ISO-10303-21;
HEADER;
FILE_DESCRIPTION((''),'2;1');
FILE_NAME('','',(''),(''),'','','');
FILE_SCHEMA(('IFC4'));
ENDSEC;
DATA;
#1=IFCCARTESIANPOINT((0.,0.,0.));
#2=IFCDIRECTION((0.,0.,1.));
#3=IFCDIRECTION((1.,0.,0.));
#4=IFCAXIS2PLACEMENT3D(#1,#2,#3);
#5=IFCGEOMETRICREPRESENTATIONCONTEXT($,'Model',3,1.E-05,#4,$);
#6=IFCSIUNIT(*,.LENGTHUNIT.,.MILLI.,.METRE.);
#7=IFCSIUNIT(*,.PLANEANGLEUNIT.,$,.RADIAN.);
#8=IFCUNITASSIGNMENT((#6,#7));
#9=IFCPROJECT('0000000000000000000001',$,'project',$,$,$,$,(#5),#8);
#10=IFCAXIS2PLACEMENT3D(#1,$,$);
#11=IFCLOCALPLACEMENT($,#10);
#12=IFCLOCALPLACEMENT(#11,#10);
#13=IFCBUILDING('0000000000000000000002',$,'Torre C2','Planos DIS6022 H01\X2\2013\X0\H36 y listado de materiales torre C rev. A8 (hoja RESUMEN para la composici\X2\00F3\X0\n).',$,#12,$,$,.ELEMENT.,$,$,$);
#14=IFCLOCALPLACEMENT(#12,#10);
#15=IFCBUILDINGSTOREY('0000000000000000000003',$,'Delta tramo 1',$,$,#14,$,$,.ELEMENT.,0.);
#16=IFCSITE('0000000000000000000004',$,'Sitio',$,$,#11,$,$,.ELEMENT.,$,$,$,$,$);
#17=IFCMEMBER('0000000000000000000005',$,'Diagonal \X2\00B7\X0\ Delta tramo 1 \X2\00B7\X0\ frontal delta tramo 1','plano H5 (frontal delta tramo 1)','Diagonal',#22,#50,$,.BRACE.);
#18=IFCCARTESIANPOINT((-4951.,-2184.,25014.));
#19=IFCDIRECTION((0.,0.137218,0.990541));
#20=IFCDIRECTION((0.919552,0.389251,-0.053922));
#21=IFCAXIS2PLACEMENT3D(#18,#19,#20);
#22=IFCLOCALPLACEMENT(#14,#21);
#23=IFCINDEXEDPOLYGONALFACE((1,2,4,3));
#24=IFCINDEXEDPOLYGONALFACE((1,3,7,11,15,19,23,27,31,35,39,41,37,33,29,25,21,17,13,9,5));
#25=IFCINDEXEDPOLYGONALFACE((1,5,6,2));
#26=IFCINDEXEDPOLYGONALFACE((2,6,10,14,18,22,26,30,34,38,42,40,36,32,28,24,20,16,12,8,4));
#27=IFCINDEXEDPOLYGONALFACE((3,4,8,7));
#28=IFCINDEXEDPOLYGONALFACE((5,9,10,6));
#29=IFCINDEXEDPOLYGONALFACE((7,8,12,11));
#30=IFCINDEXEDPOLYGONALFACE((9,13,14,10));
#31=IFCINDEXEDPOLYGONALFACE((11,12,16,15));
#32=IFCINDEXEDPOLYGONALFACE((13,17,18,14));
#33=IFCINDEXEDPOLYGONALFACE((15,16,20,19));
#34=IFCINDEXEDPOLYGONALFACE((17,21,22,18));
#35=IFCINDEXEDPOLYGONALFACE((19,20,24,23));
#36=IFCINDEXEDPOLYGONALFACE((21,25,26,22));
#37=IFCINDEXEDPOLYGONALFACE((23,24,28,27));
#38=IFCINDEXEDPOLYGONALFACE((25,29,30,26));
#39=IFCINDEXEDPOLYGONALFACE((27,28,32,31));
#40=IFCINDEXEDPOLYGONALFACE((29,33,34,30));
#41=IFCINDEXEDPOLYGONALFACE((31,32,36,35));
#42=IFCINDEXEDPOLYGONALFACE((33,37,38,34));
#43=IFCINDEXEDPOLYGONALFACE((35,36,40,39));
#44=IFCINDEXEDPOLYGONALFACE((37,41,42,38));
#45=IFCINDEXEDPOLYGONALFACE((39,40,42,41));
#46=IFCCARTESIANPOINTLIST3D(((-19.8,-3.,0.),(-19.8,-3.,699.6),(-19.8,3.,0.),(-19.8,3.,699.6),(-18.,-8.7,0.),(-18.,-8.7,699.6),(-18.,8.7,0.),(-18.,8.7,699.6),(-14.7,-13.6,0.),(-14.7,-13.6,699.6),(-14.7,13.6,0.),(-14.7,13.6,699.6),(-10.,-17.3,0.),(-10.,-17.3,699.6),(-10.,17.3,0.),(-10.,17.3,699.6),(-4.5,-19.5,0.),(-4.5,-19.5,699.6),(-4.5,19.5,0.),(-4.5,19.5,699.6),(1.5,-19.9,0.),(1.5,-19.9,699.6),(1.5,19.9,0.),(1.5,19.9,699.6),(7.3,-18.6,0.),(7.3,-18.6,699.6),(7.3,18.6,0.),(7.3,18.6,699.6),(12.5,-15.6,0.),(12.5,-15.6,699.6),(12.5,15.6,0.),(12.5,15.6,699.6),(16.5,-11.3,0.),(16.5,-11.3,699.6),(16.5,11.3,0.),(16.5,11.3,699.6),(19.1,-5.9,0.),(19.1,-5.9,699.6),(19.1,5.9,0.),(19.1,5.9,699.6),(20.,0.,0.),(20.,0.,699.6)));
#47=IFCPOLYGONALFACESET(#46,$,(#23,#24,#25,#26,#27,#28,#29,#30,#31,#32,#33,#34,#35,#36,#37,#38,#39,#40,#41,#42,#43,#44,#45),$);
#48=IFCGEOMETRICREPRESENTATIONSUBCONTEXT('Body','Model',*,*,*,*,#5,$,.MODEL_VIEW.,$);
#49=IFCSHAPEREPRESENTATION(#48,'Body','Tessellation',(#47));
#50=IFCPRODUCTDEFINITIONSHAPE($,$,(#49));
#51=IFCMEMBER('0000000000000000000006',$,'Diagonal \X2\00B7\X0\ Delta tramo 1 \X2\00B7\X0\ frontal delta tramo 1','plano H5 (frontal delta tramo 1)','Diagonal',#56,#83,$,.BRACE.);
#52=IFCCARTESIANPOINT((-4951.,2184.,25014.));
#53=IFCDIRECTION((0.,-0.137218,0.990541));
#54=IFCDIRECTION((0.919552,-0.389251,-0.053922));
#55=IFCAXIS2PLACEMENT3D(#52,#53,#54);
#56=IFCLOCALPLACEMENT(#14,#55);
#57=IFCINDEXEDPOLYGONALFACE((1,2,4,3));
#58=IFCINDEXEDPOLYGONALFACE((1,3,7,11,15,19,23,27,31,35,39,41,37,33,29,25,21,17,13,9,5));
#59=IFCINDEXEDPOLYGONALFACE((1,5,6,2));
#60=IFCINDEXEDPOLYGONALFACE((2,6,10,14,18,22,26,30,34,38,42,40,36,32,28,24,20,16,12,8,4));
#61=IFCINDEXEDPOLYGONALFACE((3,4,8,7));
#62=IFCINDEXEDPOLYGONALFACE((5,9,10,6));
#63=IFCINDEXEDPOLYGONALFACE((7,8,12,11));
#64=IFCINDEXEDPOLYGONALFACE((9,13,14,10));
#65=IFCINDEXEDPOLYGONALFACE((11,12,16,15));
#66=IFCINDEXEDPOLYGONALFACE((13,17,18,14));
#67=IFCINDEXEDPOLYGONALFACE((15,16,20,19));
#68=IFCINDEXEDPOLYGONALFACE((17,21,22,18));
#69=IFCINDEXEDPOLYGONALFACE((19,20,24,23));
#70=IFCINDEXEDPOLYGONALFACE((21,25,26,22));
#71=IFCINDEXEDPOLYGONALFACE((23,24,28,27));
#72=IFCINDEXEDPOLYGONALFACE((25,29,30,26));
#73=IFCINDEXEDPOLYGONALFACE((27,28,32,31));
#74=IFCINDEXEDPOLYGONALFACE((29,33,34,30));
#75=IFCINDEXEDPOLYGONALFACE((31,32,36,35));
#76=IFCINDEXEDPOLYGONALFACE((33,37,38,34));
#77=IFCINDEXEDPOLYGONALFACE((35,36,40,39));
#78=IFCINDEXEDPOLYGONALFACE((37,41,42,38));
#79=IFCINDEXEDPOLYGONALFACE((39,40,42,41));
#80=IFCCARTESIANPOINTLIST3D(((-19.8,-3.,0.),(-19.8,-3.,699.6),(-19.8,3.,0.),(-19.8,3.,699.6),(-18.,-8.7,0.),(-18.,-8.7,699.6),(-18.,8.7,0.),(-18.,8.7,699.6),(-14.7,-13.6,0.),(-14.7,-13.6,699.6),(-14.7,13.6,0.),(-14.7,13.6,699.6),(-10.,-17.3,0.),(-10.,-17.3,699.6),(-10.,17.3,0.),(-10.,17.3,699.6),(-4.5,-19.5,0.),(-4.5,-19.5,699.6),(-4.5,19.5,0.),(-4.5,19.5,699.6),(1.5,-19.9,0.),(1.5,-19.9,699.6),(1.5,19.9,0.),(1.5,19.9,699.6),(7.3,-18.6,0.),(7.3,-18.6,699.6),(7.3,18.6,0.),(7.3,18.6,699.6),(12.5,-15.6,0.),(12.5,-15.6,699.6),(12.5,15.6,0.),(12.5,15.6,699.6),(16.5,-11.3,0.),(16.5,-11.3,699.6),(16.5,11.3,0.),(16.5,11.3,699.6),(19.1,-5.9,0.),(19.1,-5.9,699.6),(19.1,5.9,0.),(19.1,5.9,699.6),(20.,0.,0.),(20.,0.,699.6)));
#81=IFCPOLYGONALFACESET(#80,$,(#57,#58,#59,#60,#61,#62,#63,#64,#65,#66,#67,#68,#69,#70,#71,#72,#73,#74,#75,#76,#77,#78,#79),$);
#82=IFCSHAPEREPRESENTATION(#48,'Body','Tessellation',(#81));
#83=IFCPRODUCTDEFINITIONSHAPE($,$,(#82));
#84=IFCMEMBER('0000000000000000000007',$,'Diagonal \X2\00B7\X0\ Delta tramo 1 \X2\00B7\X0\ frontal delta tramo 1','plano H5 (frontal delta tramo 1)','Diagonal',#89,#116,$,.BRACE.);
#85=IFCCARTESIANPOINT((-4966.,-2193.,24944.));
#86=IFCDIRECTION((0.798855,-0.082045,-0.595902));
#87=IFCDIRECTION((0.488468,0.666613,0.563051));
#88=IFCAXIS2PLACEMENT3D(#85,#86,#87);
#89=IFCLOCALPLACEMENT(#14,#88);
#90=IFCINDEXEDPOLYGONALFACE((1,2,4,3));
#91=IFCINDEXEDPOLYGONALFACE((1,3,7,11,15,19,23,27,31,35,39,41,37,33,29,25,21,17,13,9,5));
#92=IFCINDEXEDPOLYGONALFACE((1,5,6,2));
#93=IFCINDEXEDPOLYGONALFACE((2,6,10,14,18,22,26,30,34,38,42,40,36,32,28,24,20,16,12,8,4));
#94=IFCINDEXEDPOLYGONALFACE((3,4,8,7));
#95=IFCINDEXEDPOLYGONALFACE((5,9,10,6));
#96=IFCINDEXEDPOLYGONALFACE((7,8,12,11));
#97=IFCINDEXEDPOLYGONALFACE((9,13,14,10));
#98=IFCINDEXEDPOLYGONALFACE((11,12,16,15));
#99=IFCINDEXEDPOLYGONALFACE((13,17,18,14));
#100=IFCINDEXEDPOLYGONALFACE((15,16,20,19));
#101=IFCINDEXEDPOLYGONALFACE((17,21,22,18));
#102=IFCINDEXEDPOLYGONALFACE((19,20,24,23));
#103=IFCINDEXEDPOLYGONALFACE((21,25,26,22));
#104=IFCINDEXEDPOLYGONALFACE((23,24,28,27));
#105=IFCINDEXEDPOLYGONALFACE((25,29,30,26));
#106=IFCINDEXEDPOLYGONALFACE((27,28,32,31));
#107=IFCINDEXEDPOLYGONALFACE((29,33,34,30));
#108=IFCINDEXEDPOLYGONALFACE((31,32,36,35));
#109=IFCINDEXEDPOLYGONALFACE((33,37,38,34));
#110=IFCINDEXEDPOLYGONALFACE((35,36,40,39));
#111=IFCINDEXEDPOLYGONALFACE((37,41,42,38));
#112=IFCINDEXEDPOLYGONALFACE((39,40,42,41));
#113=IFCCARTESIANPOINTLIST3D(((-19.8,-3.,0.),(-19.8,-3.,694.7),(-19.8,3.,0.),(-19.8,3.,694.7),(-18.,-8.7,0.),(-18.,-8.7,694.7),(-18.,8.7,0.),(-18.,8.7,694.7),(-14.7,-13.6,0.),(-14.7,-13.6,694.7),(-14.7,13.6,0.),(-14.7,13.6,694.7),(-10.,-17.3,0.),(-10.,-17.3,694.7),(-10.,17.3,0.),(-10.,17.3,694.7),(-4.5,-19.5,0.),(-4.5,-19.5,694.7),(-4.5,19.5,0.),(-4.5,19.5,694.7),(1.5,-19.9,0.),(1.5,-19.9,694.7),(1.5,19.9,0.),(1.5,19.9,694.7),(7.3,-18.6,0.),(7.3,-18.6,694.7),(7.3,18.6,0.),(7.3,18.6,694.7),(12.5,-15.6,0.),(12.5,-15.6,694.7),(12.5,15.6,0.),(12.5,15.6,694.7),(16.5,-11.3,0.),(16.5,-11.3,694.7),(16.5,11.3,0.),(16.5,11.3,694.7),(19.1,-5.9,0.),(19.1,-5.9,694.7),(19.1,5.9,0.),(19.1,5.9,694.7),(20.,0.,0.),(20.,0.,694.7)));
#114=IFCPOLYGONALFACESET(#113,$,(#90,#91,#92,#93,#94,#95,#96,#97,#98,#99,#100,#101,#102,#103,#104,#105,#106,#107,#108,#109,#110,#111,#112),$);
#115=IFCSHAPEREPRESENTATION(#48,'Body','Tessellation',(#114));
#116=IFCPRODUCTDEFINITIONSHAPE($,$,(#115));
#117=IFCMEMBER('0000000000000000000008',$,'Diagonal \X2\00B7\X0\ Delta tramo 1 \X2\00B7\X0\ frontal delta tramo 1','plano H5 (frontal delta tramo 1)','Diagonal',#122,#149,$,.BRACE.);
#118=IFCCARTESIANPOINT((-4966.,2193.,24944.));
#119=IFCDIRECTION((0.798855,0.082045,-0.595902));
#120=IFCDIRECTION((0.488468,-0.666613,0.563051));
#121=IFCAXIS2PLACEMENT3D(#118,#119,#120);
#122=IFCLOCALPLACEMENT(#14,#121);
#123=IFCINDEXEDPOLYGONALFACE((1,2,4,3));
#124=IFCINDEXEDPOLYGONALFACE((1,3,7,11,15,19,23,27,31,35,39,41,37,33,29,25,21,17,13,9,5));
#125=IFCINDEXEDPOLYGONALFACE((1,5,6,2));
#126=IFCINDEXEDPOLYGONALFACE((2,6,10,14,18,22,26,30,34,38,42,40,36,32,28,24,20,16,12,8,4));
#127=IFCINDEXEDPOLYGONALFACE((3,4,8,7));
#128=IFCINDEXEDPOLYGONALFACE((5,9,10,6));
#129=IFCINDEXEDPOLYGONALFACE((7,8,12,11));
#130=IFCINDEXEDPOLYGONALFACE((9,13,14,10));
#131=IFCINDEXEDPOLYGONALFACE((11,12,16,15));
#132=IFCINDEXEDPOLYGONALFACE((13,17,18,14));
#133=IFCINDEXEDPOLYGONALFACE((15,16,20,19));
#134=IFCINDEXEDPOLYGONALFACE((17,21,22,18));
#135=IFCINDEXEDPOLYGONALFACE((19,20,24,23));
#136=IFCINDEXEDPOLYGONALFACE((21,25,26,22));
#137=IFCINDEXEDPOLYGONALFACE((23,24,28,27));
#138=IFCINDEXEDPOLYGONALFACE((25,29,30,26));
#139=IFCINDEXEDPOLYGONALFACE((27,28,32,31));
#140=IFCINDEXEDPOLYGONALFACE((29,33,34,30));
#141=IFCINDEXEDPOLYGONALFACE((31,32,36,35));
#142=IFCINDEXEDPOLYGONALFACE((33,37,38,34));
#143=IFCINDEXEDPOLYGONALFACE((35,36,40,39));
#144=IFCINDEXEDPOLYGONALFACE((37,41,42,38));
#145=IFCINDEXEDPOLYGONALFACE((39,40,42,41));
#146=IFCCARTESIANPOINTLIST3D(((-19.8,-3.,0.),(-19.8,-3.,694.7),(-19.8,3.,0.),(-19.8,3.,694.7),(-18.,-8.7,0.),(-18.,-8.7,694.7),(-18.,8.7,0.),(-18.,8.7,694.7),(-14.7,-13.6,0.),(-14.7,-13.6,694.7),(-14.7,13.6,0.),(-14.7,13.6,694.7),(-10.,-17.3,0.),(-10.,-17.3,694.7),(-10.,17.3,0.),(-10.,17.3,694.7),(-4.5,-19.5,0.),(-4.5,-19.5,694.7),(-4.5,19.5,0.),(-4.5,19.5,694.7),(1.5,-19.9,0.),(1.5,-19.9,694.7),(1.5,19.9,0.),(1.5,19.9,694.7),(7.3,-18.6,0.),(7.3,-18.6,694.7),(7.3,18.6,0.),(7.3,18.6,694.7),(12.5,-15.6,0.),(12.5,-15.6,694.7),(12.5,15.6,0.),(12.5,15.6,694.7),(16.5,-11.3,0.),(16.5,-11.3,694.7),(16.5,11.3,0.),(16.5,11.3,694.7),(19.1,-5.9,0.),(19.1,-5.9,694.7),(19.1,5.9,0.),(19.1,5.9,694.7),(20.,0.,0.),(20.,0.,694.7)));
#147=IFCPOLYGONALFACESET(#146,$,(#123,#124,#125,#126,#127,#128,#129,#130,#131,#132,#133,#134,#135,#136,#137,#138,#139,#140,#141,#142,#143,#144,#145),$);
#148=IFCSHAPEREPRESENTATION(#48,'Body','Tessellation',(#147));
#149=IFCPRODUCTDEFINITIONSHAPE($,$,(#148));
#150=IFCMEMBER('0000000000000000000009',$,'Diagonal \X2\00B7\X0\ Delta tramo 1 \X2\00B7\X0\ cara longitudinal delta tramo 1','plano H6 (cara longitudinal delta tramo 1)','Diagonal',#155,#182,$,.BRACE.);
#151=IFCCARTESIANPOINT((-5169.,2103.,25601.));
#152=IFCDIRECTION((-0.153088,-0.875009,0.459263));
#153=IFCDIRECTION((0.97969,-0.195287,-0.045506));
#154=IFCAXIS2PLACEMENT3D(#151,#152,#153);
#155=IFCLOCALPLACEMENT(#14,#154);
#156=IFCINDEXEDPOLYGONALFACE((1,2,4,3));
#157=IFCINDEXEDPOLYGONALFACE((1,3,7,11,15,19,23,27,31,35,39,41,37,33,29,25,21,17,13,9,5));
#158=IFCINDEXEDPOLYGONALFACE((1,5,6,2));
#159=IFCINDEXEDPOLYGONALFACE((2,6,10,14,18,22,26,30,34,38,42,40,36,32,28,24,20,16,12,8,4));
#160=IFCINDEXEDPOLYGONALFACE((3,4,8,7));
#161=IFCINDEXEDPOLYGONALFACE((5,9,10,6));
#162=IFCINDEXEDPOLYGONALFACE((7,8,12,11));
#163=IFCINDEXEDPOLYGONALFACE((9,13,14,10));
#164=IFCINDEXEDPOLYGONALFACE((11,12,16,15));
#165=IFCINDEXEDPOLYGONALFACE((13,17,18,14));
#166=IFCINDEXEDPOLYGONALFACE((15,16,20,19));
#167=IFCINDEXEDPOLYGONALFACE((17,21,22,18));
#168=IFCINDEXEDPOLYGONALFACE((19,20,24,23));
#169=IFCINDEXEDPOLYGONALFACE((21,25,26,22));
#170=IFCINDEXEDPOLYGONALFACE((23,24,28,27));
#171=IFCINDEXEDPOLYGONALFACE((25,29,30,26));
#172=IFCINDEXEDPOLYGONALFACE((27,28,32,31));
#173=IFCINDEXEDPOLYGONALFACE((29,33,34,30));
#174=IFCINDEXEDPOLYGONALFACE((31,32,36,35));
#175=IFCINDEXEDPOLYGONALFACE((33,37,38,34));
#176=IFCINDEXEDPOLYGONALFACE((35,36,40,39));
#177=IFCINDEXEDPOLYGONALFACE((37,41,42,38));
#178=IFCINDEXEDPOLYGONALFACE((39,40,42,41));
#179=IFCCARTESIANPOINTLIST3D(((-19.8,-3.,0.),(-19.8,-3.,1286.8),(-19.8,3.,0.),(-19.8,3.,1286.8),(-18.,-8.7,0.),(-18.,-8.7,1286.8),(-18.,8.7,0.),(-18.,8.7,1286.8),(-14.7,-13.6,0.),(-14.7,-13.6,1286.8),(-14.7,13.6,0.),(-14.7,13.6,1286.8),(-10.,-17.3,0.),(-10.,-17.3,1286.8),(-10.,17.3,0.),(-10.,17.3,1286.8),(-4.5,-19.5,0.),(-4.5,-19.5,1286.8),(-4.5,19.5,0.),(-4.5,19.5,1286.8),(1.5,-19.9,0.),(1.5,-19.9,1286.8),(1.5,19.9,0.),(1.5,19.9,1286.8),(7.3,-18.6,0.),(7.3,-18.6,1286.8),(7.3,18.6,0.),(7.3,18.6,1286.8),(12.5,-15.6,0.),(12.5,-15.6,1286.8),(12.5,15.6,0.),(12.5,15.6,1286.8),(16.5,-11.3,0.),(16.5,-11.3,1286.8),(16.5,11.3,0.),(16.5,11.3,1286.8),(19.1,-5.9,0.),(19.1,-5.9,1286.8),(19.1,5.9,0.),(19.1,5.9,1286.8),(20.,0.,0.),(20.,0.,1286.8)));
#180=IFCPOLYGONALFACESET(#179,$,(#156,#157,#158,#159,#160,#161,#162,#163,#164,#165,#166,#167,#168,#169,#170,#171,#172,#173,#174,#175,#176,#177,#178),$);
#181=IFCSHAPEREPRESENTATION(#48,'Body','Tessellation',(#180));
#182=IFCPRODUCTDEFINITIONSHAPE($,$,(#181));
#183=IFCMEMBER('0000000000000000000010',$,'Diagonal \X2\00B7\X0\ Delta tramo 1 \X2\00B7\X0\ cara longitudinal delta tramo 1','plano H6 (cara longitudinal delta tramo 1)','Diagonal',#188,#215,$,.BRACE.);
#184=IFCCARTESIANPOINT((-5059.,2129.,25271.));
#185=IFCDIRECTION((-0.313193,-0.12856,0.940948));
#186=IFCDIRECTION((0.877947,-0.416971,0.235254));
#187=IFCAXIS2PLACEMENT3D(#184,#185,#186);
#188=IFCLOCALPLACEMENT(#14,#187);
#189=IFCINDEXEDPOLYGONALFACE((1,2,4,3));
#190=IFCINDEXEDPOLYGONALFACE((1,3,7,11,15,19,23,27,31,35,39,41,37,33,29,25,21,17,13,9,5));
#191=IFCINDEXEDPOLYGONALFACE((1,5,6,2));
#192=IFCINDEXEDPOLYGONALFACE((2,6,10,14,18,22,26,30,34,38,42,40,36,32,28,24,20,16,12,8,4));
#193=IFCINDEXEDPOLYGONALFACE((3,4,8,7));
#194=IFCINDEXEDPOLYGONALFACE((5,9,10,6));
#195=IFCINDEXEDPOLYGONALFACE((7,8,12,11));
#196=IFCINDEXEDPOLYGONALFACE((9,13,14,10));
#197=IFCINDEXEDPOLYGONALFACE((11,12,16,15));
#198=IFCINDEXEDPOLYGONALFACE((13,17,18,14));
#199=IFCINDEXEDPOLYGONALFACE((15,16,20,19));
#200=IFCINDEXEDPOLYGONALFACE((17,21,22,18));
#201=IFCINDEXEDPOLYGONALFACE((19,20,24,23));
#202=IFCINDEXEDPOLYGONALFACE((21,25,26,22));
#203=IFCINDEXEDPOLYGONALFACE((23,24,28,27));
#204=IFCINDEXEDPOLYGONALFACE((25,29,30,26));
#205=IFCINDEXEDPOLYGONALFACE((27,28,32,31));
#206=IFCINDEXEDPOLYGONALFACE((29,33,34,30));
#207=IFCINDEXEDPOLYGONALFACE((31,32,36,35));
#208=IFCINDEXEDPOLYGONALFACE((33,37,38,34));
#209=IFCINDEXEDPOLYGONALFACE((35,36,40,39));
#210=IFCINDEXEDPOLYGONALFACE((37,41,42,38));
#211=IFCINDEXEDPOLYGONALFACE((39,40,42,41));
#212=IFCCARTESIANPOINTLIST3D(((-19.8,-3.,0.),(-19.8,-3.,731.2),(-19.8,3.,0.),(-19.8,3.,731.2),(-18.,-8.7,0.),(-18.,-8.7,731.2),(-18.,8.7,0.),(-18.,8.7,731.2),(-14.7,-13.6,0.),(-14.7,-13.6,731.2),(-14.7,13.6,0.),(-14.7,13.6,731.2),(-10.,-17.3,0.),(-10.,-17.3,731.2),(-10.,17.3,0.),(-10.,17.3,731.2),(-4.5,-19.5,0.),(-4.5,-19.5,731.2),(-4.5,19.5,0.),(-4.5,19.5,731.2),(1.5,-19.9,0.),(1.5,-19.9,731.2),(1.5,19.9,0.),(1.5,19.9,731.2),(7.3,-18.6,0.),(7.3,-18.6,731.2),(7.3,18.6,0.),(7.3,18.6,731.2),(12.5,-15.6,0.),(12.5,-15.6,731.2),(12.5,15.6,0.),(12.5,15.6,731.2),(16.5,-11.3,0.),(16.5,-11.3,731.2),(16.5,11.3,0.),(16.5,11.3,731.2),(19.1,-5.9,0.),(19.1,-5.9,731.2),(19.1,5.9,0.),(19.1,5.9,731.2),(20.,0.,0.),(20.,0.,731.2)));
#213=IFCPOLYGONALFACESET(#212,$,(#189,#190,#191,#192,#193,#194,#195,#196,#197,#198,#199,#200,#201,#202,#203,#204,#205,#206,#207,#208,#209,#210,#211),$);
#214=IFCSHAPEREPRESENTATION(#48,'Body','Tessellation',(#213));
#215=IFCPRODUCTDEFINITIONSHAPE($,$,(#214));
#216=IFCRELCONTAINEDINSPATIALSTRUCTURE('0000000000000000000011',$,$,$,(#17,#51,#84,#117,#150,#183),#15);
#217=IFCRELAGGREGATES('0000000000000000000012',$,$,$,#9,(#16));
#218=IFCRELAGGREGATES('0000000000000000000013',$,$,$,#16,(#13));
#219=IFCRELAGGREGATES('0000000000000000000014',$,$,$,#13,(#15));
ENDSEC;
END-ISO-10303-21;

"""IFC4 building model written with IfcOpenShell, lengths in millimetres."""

from ifc_helpers import new_model, si_unit, frame, origin, origin_with_axes, place, context, subcontext, project, spatial, circle, extrude, element, save


model = new_model("IFC4")

# Units and contexts
model_context = context("Model", 3, precision=1e-05, world=origin_with_axes())
body_context = subcontext(model_context, "Body", "Model", "MODEL_VIEW")
ifc_project = project(units=[si_unit("LENGTHUNIT", "METRE", prefix="MILLI"), si_unit("PLANEANGLEUNIT", "RADIAN")], contexts=[model_context])

# Site, building, storey
site_placement = place(None, origin())
site = spatial("IfcSite", under=ifc_project, at=site_placement, Name="Sitio", CompositionType="ELEMENT")
building_placement = place(site_placement, origin())
building = spatial("IfcBuilding", under=site, at=building_placement, Name="Torre C2", Description="Planos DIS6022 H01–H36 y listado de materiales torre C rev. A8 (hoja RESUMEN para la composición).", CompositionType="ELEMENT")
storey_placement = place(building_placement, origin())
storey = spatial("IfcBuildingStorey", under=building, at=storey_placement, Name="Delta tramo 1", CompositionType="ELEMENT", Elevation=0.0)

# Members
for number, where, z_axis, x_axis, name in (
    (1, (-4951.0, -2184.0, 25014.0), (0.0, 0.137218, 0.990541), (0.919552, 0.389251, -0.053922), "Diagonal · Delta tramo 1 · frontal delta tramo 1"),
    (2, (-4951.0, 2184.0, 25014.0), (0.0, -0.137218, 0.990541), (0.919552, -0.389251, -0.053922), "Diagonal · Delta tramo 1 · frontal delta tramo 1"),
):
    element("IfcMember", number, at=place(storey_placement, frame(where, z_axis=z_axis, x_axis=x_axis)), inside=storey, Name=name, Description="plano H5 (frontal delta tramo 1)", ObjectType="Diagonal", PredefinedType="BRACE", context=body_context, shape_type="SweptSolid", body=[
        extrude(circle(Radius=20.0), None, (0.0, 0.0, 1.0), 699.6),
    ])
for number, where, z_axis, x_axis, name in (
    (3, (-4966.0, -2193.0, 24944.0), (0.798855, -0.082045, -0.595902), (0.488468, 0.666613, 0.563051), "Diagonal · Delta tramo 1 · frontal delta tramo 1"),
    (4, (-4966.0, 2193.0, 24944.0), (0.798855, 0.082045, -0.595902), (0.488468, -0.666613, 0.563051), "Diagonal · Delta tramo 1 · frontal delta tramo 1"),
):
    element("IfcMember", number, at=place(storey_placement, frame(where, z_axis=z_axis, x_axis=x_axis)), inside=storey, Name=name, Description="plano H5 (frontal delta tramo 1)", ObjectType="Diagonal", PredefinedType="BRACE", context=body_context, shape_type="SweptSolid", body=[
        extrude(circle(Radius=20.0), None, (0.0, 0.0, 1.0), 694.7),
    ])
member_1_placement = place(storey_placement, frame((-5169.0, 2103.0, 25601.0), z_axis=(-0.153088, -0.875009, 0.459263), x_axis=(0.97969, -0.195287, -0.045506)))
element("IfcMember", 5, at=member_1_placement, inside=storey, Name="Diagonal · Delta tramo 1 · cara longitudinal delta tramo 1", Description="plano H6 (cara longitudinal delta tramo 1)", ObjectType="Diagonal", PredefinedType="BRACE", context=body_context, shape_type="SweptSolid", body=[
    extrude(circle(Radius=20.0), None, (0.0, 0.0, 1.0), 1286.8),
])
member_2_placement = place(storey_placement, frame((-5059.0, 2129.0, 25271.0), z_axis=(-0.313193, -0.12856, 0.940948), x_axis=(0.877947, -0.416971, 0.235254)))
element("IfcMember", 6, at=member_2_placement, inside=storey, Name="Diagonal · Delta tramo 1 · cara longitudinal delta tramo 1", Description="plano H6 (cara longitudinal delta tramo 1)", ObjectType="Diagonal", PredefinedType="BRACE", context=body_context, shape_type="SweptSolid", body=[
    extrude(circle(Radius=20.0), None, (0.0, 0.0, 1.0), 731.2),
])

save(model, "model.ifc")
